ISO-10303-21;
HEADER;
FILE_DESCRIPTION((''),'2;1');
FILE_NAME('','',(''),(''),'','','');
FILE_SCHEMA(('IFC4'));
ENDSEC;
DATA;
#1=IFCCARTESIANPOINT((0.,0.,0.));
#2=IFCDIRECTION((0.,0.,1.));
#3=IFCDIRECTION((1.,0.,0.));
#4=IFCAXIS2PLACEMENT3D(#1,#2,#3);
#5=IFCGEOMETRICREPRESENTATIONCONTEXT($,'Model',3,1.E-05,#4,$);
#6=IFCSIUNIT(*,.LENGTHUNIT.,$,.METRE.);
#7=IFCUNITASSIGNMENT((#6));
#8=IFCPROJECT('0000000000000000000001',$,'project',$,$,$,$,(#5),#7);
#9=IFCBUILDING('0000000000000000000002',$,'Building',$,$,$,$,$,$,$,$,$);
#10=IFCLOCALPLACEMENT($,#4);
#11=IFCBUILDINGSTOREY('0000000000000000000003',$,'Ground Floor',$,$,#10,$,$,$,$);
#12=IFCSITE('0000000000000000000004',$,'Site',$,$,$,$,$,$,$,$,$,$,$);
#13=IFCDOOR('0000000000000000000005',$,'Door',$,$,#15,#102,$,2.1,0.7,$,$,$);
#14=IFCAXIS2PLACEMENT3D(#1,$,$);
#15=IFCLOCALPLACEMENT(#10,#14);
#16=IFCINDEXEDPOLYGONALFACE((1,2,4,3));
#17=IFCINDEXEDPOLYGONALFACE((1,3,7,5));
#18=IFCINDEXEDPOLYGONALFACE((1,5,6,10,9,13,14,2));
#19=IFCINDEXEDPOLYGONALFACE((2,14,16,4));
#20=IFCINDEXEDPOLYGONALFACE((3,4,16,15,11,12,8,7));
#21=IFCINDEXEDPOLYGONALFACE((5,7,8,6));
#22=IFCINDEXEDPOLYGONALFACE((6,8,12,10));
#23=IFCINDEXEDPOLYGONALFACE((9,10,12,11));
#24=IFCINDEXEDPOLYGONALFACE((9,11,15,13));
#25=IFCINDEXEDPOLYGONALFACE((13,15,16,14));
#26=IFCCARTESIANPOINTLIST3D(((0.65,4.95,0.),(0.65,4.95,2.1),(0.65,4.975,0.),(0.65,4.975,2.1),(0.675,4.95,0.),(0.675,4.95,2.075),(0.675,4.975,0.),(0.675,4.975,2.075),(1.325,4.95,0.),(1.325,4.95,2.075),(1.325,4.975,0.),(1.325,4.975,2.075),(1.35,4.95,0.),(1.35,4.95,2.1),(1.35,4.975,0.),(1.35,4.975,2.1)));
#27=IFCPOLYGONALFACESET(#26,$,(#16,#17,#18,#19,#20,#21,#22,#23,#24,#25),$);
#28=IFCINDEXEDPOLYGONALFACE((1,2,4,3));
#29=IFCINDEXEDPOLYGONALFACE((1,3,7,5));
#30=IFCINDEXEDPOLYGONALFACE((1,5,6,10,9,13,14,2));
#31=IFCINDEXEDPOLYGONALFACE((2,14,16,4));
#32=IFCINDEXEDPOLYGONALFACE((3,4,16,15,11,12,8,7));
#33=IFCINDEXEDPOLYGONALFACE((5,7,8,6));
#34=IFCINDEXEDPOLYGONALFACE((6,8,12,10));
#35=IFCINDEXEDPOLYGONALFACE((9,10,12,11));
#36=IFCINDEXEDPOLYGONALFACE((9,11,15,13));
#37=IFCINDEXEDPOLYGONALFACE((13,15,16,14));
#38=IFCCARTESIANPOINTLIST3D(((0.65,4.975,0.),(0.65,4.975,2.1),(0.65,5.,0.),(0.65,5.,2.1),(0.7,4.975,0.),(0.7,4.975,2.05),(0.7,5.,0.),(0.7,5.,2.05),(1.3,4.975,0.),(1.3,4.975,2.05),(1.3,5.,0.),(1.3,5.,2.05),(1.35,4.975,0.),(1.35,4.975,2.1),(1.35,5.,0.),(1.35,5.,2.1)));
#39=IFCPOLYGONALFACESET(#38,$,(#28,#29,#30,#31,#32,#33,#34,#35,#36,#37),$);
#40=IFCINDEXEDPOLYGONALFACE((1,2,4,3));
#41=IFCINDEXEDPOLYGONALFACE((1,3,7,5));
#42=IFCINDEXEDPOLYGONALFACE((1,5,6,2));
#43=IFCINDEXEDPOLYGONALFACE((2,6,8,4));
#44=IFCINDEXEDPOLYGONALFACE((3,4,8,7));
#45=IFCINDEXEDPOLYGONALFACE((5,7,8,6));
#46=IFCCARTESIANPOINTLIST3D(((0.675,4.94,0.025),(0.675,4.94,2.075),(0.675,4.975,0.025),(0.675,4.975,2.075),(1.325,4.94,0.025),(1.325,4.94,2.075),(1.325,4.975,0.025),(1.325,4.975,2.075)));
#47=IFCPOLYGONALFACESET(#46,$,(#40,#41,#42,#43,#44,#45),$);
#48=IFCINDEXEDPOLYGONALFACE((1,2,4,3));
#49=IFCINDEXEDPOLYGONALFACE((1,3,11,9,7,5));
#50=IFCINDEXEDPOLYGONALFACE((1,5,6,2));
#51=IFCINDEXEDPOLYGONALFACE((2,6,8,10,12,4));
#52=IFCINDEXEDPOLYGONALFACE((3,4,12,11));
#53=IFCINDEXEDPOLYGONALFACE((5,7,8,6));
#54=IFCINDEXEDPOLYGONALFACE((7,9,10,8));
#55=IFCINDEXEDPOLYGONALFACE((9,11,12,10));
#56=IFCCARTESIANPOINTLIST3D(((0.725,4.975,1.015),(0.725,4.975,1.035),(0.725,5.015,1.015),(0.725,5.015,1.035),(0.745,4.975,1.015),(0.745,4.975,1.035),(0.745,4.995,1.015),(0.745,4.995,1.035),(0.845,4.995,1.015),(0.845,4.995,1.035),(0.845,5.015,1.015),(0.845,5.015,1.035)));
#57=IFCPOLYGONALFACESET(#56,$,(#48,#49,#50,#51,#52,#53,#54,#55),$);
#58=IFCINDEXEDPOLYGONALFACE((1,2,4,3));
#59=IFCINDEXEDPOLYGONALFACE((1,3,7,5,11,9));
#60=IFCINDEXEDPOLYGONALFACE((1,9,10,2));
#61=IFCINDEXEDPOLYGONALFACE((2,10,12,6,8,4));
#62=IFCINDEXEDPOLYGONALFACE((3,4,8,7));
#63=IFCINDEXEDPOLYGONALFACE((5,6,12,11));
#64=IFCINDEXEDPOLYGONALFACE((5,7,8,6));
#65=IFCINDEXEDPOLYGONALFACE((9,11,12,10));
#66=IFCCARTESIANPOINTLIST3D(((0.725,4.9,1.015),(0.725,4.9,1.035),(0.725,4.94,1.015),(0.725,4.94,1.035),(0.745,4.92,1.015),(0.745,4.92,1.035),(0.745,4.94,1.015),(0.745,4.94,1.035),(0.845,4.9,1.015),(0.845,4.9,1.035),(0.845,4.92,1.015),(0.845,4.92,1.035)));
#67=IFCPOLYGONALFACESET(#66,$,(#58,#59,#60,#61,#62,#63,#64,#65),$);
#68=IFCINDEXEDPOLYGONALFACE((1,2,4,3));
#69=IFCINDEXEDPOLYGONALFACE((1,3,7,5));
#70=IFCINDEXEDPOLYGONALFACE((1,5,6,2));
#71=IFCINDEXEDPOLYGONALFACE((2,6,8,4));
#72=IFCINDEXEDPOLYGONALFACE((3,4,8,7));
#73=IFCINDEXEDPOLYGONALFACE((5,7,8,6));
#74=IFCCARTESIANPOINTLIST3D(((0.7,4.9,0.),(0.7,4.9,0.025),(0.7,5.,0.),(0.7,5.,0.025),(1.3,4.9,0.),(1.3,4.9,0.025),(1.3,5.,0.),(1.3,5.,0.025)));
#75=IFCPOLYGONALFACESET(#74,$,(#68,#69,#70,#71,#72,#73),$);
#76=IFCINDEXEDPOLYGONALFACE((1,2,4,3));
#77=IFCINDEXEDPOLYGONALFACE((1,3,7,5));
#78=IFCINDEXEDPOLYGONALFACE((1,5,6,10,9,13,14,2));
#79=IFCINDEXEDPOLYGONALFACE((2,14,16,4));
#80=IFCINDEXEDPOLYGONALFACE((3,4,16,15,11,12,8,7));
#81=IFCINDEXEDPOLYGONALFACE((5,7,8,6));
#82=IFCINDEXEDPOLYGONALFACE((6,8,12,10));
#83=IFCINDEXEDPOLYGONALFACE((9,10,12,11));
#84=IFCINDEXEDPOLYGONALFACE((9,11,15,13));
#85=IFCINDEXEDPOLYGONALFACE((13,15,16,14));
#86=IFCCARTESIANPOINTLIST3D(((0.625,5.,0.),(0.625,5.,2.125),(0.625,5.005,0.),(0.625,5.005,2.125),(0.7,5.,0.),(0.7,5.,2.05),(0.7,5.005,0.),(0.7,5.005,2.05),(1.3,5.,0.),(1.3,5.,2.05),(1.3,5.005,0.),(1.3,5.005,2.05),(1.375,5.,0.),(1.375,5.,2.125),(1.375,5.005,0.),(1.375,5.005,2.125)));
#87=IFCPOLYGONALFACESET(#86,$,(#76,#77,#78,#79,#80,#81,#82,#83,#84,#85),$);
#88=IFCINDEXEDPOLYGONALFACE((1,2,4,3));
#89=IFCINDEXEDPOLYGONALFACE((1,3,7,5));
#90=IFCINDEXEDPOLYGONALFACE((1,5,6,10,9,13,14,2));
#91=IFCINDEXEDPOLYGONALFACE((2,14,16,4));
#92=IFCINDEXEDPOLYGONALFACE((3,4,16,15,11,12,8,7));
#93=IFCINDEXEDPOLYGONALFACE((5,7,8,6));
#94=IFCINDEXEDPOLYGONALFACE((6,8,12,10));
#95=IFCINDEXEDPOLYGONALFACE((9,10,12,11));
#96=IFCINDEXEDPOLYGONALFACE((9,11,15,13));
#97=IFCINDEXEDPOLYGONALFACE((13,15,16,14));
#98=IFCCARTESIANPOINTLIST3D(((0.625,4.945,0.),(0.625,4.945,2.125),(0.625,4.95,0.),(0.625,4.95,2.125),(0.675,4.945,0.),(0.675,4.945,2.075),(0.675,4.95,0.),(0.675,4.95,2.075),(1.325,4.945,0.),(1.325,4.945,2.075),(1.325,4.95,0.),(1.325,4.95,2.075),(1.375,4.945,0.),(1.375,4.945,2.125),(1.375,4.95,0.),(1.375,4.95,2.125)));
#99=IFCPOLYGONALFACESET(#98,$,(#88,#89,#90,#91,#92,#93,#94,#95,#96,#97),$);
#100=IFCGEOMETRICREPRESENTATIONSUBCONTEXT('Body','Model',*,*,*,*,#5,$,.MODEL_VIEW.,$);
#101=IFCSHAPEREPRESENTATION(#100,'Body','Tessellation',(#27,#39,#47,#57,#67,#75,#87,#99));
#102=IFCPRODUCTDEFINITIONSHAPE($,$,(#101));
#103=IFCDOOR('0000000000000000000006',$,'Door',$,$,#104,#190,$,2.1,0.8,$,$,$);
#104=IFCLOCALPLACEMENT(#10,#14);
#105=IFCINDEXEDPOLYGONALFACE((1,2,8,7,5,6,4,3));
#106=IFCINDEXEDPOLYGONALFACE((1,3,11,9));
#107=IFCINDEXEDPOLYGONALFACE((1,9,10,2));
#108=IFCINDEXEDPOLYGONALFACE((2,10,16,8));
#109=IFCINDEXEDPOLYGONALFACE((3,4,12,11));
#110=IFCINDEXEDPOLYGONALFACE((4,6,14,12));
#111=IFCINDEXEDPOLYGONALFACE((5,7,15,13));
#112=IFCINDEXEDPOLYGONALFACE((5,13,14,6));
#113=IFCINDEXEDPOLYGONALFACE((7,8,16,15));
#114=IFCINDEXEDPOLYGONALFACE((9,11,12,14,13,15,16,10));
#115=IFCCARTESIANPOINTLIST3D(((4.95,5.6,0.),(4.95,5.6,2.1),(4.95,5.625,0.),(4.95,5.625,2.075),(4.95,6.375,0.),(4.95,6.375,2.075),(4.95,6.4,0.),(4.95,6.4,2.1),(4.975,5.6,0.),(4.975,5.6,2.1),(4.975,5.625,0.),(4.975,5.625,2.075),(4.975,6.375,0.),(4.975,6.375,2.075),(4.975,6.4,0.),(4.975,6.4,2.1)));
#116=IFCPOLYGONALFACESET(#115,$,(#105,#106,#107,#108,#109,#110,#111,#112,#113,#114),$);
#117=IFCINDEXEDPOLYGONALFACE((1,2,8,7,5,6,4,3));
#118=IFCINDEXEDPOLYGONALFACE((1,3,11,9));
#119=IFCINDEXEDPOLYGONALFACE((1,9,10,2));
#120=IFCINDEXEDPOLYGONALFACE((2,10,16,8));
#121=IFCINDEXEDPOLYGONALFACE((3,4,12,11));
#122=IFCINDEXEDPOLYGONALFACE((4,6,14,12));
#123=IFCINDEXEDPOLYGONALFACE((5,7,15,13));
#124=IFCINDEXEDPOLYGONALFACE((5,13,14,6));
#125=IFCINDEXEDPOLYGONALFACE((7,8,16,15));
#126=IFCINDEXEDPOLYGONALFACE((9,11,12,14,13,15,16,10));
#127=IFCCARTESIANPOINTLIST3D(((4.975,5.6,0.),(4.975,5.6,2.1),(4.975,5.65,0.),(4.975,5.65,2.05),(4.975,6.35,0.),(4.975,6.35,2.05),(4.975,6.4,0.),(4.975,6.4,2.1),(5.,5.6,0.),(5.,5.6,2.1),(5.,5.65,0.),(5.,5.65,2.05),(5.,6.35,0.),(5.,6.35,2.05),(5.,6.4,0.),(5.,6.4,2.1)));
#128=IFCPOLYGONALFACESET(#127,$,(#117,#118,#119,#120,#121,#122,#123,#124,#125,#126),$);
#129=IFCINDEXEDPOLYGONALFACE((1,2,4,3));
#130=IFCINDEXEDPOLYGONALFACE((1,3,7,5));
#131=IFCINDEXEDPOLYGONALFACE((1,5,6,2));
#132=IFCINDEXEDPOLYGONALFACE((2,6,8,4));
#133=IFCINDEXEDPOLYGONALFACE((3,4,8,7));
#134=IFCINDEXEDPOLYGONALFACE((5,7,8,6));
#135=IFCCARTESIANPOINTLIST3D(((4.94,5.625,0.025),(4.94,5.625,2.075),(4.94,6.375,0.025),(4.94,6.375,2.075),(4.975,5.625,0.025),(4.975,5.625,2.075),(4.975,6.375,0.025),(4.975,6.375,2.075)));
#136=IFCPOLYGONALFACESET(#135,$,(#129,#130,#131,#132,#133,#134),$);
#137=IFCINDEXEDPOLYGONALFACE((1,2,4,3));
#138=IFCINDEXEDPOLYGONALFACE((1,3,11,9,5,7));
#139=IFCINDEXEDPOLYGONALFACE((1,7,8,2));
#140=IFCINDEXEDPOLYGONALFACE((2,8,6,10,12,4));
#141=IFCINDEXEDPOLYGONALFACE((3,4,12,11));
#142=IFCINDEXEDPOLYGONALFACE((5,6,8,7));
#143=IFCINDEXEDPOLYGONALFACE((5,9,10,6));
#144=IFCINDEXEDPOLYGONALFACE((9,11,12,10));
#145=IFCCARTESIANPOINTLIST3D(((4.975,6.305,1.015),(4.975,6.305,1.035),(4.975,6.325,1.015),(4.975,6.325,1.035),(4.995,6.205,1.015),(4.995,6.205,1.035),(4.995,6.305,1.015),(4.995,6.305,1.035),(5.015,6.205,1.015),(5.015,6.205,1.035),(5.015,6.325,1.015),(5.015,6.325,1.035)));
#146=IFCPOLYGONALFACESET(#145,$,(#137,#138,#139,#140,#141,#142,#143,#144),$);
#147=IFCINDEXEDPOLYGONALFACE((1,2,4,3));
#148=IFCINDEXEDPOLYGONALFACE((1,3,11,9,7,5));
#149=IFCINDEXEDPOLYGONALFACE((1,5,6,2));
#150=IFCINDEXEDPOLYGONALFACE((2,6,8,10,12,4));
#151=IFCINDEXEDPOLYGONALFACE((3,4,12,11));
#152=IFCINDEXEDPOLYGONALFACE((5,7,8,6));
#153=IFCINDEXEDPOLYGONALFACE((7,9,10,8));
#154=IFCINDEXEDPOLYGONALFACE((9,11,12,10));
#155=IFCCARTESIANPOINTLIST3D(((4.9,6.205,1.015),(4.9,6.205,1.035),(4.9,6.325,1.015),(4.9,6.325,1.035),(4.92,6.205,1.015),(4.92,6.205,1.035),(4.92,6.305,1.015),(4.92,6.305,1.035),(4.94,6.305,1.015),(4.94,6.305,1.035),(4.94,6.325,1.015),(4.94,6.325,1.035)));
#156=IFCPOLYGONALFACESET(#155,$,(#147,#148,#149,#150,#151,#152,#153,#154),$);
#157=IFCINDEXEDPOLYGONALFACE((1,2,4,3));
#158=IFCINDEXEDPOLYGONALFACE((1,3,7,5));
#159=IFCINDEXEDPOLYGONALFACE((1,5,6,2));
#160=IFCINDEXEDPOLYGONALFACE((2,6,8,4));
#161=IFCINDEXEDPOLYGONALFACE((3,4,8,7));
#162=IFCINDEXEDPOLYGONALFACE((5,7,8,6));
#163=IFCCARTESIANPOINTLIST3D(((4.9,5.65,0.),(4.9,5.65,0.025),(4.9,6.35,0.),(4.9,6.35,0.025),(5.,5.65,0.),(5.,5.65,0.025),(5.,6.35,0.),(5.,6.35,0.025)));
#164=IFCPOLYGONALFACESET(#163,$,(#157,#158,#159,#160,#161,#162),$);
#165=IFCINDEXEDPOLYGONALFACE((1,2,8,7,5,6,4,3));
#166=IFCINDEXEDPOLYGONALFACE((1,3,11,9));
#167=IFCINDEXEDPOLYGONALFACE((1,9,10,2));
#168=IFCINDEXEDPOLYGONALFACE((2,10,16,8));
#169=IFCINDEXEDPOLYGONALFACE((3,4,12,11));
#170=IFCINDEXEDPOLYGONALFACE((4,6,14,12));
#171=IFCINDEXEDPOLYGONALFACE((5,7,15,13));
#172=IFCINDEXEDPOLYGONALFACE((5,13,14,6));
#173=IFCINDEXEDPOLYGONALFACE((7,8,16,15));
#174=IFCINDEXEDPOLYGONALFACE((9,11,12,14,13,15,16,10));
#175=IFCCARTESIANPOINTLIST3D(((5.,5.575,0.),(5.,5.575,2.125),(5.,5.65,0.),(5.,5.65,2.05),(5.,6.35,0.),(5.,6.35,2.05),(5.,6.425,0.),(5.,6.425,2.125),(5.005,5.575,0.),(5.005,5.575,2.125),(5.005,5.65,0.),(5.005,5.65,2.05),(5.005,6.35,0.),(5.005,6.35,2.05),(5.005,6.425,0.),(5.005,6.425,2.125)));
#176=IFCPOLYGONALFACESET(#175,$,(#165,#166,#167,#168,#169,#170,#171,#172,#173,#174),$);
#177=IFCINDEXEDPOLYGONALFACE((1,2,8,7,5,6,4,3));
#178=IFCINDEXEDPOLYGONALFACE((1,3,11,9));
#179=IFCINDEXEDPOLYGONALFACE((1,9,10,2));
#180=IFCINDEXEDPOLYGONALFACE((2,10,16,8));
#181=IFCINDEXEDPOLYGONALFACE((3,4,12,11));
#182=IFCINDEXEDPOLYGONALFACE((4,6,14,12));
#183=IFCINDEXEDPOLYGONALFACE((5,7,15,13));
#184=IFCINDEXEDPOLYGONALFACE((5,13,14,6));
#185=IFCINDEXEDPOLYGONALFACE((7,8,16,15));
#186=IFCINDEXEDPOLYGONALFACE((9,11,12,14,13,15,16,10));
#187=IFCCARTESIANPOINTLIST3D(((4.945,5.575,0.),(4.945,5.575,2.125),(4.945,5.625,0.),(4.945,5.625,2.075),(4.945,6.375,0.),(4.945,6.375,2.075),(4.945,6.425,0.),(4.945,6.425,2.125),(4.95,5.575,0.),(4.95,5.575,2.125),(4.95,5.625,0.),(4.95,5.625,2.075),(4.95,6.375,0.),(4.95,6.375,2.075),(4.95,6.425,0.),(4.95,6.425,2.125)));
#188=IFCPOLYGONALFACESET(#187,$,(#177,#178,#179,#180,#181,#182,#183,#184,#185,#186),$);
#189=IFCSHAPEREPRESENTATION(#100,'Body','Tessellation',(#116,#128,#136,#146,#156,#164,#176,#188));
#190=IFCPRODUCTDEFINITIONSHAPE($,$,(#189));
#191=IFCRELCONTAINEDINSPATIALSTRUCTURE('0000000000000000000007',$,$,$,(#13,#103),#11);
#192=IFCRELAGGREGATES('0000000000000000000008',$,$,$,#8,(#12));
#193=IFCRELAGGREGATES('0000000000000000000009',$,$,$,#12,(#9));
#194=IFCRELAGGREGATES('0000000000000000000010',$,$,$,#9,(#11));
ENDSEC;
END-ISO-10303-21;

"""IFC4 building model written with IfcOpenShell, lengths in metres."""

from ifc_helpers import new_model, si_unit, frame, origin_with_axes, place, context, subcontext, project, spatial, line, indexed_curve, outline, extrude, element, save


model = new_model("IFC4")

# Units and contexts
model_context = context("Model", 3, precision=1e-05, world=origin_with_axes())
body_context = subcontext(model_context, "Body", "Model", "MODEL_VIEW")
ifc_project = project(units=[si_unit("LENGTHUNIT", "METRE")], contexts=[model_context])

# Site, building, storey
site = spatial("IfcSite", under=ifc_project, Name="Site")
building = spatial("IfcBuilding", under=site, Name="Building")
storey_placement = place(None, origin_with_axes())
storey = spatial("IfcBuildingStorey", under=building, at=storey_placement, Name="Ground Floor")

# Doors
door_1_placement = place(storey_placement, frame((1.35, 5.0, 0.0), z_axis=(0.0, 0.0, 1.0), x_axis=(-1.0, 0.0, 0.0)))
element("IfcDoor", 1, at=door_1_placement, inside=storey, Name="Door", OverallHeight=2.1, OverallWidth=0.7, context=body_context, shape_type="SweptSolid", body=[
    extrude(outline(indexed_curve([(0.0, 0.0), (0.0, 2.1), (0.7, 2.1), (0.7, 0.0), (0.675, 0.0), (0.675, 2.075), (0.025, 2.075), (0.025, 0.0)], segments=[line(1, 2, 3, 4, 5, 6, 7, 8, 1)])), frame((0.0, 0.025, 0.0), z_axis=(0.0, -1.0, 0.0), x_axis=(1.0, 0.0, 0.0)), (0.0, 0.0, -1.0), 0.025),
    extrude(outline(indexed_curve([(0.0, 0.0), (0.0, 2.1), (0.7, 2.1), (0.7, 0.0), (0.65, 0.0), (0.65, 2.05), (0.05, 2.05), (0.05, 0.0)], segments=[line(1, 2, 3, 4, 5, 6, 7, 8, 1)])), frame((0.0, 0.0, 0.0), z_axis=(0.0, -1.0, 0.0), x_axis=(1.0, 0.0, 0.0)), (0.0, 0.0, -1.0), 0.025),
    extrude(outline(indexed_curve([(0.0, 0.0), (0.65, 0.0), (0.65, 0.035), (0.0, 0.035)], segments=[line(1, 2, 3, 4, 1)])), frame((0.025, 0.025, 0.025), z_axis=(0.0, 0.0, 1.0), x_axis=(1.0, 0.0, 0.0)), (0.0, 0.0, 1.0), 2.05),
    extrude(outline(indexed_curve([(0.0, 0.0), (0.0, -0.04), (-0.12, -0.04), (-0.12, -0.02), (-0.02, -0.02), (-0.02, 0.0)], segments=[line(1, 2, 3, 4, 5, 6, 1)])), frame((0.625, 0.025, 1.015), z_axis=(0.0, 0.0, 1.0), x_axis=(1.0, 0.0, 0.0)), (0.0, 0.0, 1.0), 0.02),
    extrude(outline(indexed_curve([(0.0, 0.0), (0.0, 0.04), (-0.12, 0.04), (-0.12, 0.02), (-0.02, 0.02), (-0.02, 0.0)], segments=[line(1, 2, 3, 4, 5, 6, 1)])), frame((0.625, 0.06, 1.015), z_axis=(0.0, 0.0, 1.0), x_axis=(1.0, 0.0, 0.0)), (0.0, 0.0, 1.0), 0.02),
    extrude(outline(indexed_curve([(0.0, 0.0), (0.6, 0.0), (0.6, 0.1), (0.0, 0.1)], segments=[line(1, 2, 3, 4, 1)])), frame((0.05, 0.0, 0.0), z_axis=(0.0, 0.0, 1.0), x_axis=(1.0, 0.0, 0.0)), (0.0, 0.0, 1.0), 0.025),
    extrude(outline(indexed_curve([(0.0, 0.0), (0.0, 2.125), (0.75, 2.125), (0.75, 0.0), (0.675, 0.0), (0.675, 2.05), (0.075, 2.05), (0.075, 0.0)], segments=[line(1, 2, 3, 4, 5, 6, 7, 8, 1)])), frame((-0.025, -0.005, 0.0), z_axis=(0.0, -1.0, 0.0), x_axis=(1.0, 0.0, 0.0)), (0.0, 0.0, -1.0), 0.005),
    extrude(outline(indexed_curve([(0.0, 0.0), (0.0, 2.125), (0.75, 2.125), (0.75, 0.0), (0.7, 0.0), (0.7, 2.075), (0.05, 2.075), (0.05, 0.0)], segments=[line(1, 2, 3, 4, 5, 6, 7, 8, 1)])), frame((-0.025, 0.05, 0.0), z_axis=(0.0, -1.0, 0.0), x_axis=(1.0, 0.0, 0.0)), (0.0, 0.0, -1.0), 0.005),
])
door_2_placement = place(storey_placement, frame((5.0, 5.6, 0.0), z_axis=(0.0, 0.0, 1.0), x_axis=(0.0, 1.0, 0.0)))
element("IfcDoor", 2, at=door_2_placement, inside=storey, Name="Door", OverallHeight=2.1, OverallWidth=0.8, context=body_context, shape_type="SweptSolid", body=[
    extrude(outline(indexed_curve([(0.0, 0.0), (0.0, 2.1), (0.8, 2.1), (0.8, 0.0), (0.775, 0.0), (0.775, 2.075), (0.025, 2.075), (0.025, 0.0)], segments=[line(1, 2, 3, 4, 5, 6, 7, 8, 1)])), frame((0.0, 0.025, 0.0), z_axis=(0.0, -1.0, 0.0), x_axis=(1.0, 0.0, 0.0)), (0.0, 0.0, -1.0), 0.025),
    extrude(outline(indexed_curve([(0.0, 0.0), (0.0, 2.1), (0.8, 2.1), (0.8, 0.0), (0.75, 0.0), (0.75, 2.05), (0.05, 2.05), (0.05, 0.0)], segments=[line(1, 2, 3, 4, 5, 6, 7, 8, 1)])), frame((0.0, 0.0, 0.0), z_axis=(0.0, -1.0, 0.0), x_axis=(1.0, 0.0, 0.0)), (0.0, 0.0, -1.0), 0.025),
    extrude(outline(indexed_curve([(0.0, 0.0), (0.75, 0.0), (0.75, 0.035), (0.0, 0.035)], segments=[line(1, 2, 3, 4, 1)])), frame((0.025, 0.025, 0.025), z_axis=(0.0, 0.0, 1.0), x_axis=(1.0, 0.0, 0.0)), (0.0, 0.0, 1.0), 2.05),
    extrude(outline(indexed_curve([(0.0, 0.0), (0.0, -0.04), (-0.12, -0.04), (-0.12, -0.02), (-0.02, -0.02), (-0.02, 0.0)], segments=[line(1, 2, 3, 4, 5, 6, 1)])), frame((0.725, 0.025, 1.015), z_axis=(0.0, 0.0, 1.0), x_axis=(1.0, 0.0, 0.0)), (0.0, 0.0, 1.0), 0.02),
    extrude(outline(indexed_curve([(0.0, 0.0), (0.0, 0.04), (-0.12, 0.04), (-0.12, 0.02), (-0.02, 0.02), (-0.02, 0.0)], segments=[line(1, 2, 3, 4, 5, 6, 1)])), frame((0.725, 0.06, 1.015), z_axis=(0.0, 0.0, 1.0), x_axis=(1.0, 0.0, 0.0)), (0.0, 0.0, 1.0), 0.02),
    extrude(outline(indexed_curve([(0.0, 0.0), (0.7, 0.0), (0.7, 0.1), (0.0, 0.1)], segments=[line(1, 2, 3, 4, 1)])), frame((0.05, 0.0, 0.0), z_axis=(0.0, 0.0, 1.0), x_axis=(1.0, 0.0, 0.0)), (0.0, 0.0, 1.0), 0.025),
    extrude(outline(indexed_curve([(0.0, 0.0), (0.0, 2.125), (0.85, 2.125), (0.85, 0.0), (0.775, 0.0), (0.775, 2.05), (0.075, 2.05), (0.075, 0.0)], segments=[line(1, 2, 3, 4, 5, 6, 7, 8, 1)])), frame((-0.025, -0.005, 0.0), z_axis=(0.0, -1.0, 0.0), x_axis=(1.0, 0.0, 0.0)), (0.0, 0.0, -1.0), 0.005),
    extrude(outline(indexed_curve([(0.0, 0.0), (0.0, 2.125), (0.85, 2.125), (0.85, 0.0), (0.8, 0.0), (0.8, 2.075), (0.05, 2.075), (0.05, 0.0)], segments=[line(1, 2, 3, 4, 5, 6, 7, 8, 1)])), frame((-0.025, 0.05, 0.0), z_axis=(0.0, -1.0, 0.0), x_axis=(1.0, 0.0, 0.0)), (0.0, 0.0, -1.0), 0.005),
])

save(model, "model.ifc")
